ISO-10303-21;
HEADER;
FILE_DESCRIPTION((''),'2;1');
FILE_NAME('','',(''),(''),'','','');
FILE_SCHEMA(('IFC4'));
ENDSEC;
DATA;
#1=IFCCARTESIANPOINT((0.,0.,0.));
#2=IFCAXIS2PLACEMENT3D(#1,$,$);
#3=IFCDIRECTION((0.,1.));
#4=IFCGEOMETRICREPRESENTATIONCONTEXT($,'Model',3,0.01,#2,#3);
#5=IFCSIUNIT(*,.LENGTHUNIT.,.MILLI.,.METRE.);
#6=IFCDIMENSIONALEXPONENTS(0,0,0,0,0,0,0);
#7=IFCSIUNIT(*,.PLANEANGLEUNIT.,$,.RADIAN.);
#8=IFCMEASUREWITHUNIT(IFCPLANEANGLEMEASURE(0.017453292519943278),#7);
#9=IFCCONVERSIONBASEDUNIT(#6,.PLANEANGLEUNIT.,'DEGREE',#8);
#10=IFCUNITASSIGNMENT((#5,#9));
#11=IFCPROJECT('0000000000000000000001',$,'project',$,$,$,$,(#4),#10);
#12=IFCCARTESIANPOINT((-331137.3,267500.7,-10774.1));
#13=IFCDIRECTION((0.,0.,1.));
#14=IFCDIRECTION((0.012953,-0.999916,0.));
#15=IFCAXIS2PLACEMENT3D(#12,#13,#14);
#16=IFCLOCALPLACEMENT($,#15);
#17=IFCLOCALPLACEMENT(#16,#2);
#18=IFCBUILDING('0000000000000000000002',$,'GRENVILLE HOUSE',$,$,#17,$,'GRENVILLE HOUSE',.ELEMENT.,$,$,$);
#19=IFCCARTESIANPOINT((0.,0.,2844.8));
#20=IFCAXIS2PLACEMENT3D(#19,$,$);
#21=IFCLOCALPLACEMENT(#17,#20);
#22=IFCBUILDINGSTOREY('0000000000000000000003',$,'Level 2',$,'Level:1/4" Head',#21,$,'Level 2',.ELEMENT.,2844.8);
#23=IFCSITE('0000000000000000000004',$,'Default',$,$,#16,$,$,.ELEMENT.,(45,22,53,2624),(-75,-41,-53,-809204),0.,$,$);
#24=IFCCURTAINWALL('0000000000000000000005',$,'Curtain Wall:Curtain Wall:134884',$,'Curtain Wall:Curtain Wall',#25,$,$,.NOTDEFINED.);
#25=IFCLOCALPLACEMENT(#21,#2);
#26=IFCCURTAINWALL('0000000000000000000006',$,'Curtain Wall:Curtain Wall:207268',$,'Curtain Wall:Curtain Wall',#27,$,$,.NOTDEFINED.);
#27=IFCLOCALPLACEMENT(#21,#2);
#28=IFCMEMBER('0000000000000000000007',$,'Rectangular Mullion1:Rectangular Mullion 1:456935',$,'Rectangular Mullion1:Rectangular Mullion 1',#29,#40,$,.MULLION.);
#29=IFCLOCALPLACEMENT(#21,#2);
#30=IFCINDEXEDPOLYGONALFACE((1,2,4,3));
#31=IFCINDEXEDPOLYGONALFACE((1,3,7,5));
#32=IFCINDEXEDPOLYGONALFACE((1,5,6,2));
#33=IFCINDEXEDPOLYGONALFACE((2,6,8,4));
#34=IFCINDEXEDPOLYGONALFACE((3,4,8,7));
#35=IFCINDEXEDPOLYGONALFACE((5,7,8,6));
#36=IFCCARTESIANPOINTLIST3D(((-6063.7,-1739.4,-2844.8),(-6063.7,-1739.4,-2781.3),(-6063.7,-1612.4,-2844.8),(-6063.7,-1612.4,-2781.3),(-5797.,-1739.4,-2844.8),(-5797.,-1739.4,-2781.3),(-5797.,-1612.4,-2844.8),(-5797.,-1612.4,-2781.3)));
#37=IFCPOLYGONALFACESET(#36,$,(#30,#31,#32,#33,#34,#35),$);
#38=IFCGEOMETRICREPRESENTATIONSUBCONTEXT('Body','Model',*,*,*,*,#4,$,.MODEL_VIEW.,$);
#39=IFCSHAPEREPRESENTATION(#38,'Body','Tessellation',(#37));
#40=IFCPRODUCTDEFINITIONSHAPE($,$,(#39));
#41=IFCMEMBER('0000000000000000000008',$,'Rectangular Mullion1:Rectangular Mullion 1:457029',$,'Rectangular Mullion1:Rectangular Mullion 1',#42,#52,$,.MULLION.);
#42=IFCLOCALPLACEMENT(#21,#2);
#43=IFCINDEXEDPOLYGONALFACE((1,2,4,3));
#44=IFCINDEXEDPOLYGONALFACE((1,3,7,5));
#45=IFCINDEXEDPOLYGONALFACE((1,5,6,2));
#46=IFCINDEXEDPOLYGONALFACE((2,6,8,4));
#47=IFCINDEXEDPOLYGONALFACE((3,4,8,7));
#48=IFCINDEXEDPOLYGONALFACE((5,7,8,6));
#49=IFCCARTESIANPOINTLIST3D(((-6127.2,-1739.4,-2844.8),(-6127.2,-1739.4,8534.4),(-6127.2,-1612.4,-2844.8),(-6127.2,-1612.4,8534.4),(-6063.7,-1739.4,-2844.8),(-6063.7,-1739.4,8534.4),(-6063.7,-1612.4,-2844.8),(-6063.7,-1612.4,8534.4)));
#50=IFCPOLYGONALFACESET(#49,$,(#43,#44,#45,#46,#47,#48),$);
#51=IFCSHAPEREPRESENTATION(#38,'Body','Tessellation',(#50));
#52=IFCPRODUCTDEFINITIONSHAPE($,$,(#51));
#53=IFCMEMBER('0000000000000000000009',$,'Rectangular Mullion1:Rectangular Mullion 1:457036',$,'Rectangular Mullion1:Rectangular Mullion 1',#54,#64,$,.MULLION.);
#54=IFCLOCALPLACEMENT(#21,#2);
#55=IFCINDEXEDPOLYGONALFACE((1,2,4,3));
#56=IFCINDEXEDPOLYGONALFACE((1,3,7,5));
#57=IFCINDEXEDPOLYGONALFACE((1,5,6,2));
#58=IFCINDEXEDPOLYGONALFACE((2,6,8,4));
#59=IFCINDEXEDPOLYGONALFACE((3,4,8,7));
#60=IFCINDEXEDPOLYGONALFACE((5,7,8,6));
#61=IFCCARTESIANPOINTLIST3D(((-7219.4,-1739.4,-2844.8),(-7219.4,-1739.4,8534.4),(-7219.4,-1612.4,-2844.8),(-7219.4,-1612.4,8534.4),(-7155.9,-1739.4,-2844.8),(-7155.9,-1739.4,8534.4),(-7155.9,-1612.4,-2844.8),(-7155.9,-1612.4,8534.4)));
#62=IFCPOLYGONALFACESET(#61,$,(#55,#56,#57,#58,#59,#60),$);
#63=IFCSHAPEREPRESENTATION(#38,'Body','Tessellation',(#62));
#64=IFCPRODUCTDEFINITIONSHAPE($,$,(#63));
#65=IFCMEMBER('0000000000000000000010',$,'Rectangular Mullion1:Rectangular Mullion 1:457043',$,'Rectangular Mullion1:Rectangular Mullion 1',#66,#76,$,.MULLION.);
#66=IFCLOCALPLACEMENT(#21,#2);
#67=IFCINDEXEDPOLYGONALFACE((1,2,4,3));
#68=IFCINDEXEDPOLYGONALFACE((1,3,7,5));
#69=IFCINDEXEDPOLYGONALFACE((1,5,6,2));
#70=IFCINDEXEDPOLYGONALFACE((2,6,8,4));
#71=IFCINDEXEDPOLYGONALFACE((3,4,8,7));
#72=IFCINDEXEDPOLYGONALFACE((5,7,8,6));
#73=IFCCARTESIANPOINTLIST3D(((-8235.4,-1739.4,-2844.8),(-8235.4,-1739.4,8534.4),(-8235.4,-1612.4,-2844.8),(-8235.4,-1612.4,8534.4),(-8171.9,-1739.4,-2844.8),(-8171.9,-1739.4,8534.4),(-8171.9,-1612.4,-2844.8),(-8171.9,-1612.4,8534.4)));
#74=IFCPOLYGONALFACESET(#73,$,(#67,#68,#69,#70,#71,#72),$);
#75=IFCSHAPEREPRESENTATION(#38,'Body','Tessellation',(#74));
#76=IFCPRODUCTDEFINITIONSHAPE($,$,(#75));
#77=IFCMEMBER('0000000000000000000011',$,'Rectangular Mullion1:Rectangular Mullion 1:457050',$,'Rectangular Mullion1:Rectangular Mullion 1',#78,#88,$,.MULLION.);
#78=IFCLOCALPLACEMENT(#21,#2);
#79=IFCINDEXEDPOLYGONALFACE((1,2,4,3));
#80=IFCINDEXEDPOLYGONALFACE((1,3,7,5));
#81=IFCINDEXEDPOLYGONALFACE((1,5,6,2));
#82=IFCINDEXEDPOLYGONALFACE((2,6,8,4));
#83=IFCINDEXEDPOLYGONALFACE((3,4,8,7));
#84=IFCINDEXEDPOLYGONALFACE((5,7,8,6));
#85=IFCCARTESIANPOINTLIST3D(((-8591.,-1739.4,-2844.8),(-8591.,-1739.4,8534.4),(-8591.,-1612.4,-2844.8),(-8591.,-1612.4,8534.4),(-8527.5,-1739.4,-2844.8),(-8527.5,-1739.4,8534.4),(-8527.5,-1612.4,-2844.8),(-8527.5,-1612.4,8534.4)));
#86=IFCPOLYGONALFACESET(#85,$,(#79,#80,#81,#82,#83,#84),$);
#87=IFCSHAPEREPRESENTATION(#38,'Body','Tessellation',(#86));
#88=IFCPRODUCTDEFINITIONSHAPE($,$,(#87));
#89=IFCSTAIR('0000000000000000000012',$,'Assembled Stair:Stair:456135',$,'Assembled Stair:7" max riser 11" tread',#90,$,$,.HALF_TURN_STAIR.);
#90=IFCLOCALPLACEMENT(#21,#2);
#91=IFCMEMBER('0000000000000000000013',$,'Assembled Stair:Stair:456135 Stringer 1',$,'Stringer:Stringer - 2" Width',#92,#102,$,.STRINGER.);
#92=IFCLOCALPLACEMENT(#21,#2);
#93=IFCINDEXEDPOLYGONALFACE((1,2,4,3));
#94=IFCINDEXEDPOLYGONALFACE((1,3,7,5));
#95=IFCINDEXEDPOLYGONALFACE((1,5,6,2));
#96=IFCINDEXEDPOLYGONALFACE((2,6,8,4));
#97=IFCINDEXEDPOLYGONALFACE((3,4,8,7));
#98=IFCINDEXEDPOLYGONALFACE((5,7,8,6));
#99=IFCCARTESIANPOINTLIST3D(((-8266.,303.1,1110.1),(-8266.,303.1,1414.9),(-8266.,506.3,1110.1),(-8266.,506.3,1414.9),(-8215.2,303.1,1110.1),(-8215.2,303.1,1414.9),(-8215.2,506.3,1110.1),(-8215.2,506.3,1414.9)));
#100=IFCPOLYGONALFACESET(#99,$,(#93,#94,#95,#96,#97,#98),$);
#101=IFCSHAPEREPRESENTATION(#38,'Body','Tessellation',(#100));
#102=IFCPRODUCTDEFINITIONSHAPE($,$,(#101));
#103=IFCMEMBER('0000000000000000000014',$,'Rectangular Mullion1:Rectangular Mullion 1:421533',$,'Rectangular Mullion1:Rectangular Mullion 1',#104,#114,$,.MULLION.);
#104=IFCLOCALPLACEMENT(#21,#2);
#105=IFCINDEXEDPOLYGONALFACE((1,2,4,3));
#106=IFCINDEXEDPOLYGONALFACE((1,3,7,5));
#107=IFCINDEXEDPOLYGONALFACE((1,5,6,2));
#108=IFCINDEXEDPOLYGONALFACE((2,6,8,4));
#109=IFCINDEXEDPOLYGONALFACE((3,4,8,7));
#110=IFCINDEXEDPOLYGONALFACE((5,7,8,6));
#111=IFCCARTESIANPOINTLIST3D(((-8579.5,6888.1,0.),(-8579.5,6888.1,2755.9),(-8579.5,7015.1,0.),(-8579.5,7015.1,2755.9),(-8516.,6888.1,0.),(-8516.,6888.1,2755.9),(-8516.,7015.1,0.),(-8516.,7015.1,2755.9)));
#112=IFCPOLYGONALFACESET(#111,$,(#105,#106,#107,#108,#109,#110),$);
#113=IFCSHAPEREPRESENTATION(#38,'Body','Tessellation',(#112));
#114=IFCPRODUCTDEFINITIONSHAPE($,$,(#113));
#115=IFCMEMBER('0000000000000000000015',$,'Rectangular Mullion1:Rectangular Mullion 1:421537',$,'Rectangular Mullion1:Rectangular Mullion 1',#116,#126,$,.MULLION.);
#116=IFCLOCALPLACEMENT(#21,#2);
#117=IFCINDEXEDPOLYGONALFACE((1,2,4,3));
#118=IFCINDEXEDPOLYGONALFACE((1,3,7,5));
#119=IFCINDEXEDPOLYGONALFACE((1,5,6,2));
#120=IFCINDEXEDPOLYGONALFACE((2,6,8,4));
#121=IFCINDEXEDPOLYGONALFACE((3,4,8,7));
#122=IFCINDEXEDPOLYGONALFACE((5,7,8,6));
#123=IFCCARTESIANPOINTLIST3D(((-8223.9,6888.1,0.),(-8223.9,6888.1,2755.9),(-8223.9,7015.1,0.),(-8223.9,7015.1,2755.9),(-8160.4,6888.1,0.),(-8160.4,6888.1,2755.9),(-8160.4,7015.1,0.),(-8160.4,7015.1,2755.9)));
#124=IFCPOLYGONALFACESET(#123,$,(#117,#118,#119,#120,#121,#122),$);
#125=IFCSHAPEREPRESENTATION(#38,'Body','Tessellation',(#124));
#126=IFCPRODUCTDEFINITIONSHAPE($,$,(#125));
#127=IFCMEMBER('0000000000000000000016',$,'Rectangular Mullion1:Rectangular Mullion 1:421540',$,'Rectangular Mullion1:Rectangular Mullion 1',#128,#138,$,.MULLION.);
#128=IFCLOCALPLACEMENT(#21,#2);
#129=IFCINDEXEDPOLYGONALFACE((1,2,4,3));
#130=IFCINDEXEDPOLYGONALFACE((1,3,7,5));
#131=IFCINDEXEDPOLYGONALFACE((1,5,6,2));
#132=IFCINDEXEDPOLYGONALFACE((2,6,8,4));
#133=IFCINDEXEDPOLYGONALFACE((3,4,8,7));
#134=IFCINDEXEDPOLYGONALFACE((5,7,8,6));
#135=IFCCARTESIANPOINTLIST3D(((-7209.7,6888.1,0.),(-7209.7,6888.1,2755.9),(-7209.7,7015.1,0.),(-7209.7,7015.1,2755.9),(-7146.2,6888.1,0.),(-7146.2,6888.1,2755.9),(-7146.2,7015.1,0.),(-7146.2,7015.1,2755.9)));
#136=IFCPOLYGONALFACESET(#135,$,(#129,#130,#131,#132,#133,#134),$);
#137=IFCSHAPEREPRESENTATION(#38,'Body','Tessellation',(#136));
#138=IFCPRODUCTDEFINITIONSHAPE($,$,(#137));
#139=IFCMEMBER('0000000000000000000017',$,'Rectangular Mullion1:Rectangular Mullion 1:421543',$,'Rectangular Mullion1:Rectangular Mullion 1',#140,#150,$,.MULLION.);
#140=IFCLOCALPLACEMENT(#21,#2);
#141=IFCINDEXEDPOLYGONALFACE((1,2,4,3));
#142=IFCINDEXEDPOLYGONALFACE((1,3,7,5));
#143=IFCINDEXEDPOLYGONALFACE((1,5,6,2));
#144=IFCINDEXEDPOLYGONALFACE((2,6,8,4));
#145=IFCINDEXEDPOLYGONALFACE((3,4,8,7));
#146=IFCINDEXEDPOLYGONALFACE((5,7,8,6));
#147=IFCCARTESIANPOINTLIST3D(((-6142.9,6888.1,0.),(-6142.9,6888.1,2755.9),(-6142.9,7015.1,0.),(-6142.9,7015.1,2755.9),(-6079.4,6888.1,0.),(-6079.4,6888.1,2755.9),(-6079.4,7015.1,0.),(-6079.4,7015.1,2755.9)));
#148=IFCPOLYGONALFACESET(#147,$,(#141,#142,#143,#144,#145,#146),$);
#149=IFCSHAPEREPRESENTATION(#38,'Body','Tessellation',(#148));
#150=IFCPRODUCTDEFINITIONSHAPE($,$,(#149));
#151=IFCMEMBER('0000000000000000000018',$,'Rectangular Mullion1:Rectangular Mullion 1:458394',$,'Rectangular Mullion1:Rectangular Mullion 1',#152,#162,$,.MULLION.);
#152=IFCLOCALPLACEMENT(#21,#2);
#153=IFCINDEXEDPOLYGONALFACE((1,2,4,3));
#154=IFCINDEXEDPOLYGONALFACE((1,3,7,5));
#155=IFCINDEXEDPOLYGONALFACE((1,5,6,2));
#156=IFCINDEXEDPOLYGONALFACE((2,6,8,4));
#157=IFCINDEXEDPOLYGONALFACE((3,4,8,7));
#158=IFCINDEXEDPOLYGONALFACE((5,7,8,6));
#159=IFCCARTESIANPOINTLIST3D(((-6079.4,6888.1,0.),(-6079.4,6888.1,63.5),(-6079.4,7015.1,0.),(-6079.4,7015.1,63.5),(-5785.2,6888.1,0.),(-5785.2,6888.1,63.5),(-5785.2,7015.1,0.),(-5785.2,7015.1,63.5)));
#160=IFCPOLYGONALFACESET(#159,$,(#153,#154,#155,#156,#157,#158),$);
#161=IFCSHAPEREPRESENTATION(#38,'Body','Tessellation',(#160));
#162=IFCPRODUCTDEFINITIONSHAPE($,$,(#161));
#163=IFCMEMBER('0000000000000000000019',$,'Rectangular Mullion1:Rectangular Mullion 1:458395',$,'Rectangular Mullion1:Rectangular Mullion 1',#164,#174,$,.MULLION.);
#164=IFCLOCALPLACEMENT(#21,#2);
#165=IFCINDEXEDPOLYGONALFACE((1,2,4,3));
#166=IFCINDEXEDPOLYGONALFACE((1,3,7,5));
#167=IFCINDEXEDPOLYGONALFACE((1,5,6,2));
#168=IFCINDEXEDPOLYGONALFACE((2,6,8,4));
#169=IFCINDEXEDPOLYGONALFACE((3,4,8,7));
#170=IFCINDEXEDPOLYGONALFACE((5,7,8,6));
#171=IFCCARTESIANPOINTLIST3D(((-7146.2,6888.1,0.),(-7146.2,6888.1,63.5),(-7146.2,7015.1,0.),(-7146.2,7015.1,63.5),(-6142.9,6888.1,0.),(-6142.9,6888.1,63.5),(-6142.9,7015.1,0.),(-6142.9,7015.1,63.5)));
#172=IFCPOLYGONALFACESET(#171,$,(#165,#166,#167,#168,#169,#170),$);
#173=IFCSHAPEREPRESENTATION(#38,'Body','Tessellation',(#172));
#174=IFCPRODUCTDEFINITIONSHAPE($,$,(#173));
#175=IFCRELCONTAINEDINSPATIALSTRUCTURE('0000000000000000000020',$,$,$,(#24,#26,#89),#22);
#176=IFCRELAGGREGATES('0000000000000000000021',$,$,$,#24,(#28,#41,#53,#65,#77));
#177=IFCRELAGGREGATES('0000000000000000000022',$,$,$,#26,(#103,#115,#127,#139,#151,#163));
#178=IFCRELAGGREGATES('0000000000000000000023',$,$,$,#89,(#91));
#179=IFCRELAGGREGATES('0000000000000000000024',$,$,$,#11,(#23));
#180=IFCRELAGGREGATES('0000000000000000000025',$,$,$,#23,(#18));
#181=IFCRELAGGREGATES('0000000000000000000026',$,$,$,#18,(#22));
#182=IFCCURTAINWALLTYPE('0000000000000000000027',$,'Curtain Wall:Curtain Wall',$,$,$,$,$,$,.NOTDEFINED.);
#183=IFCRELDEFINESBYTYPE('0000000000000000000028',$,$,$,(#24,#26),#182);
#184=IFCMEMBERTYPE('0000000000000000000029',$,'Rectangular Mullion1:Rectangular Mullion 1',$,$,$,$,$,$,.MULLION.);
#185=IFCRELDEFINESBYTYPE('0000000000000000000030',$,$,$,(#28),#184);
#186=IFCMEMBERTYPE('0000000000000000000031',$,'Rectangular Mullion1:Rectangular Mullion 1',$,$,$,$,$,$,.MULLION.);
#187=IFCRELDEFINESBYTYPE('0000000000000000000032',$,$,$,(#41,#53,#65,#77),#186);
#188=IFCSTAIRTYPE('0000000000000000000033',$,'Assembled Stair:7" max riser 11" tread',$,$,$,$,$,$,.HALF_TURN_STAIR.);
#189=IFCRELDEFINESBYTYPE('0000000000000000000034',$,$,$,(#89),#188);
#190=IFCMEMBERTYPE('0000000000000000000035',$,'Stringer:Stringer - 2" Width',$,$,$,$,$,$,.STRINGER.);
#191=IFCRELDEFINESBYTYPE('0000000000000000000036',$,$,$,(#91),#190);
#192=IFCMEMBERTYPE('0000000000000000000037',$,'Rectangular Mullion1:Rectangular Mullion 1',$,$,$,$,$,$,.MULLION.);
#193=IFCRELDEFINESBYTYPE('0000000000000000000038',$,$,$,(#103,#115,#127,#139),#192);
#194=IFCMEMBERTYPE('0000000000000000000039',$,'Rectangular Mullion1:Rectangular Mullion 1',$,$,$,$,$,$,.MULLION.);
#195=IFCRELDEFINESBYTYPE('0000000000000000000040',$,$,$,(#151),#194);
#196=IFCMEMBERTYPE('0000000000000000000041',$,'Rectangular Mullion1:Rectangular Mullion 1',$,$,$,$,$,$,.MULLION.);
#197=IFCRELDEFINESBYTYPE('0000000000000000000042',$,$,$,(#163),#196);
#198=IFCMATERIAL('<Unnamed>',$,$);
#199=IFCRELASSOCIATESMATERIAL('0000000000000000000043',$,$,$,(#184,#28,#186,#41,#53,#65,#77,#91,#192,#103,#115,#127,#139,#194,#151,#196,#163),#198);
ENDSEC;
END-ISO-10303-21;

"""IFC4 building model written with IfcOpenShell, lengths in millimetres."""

from ifc_helpers import new_model, entity, si_unit, converted_unit, direction, frame, origin, place, context, subcontext, project, spatial, indexed_curve, outline, extrude, source, transform, mapped, material, type_object, type_shapes, element, aggregate, save


model = new_model("IFC4")

# Units and contexts
model_context = context("Model", 3, precision=0.01, world=origin(), true_north=direction((0.0, 1.0)))
body_context = subcontext(model_context, "Body", "Model", "MODEL_VIEW")
ifc_project = project(units=[si_unit("LENGTHUNIT", "METRE", prefix="MILLI"), converted_unit("PLANEANGLEUNIT", "DEGREE", entity("IfcPlaneAngleMeasure", 0.017453292519943278), si_unit("PLANEANGLEUNIT", "RADIAN"), dimensions=[0, 0, 0, 0, 0, 0, 0])], contexts=[model_context])

# Site, building, storey
site_placement = place(None, frame((-331137.3, 267500.7, -10774.1), z_axis=(0.0, 0.0, 1.0), x_axis=(0.012953, -0.999916, 0.0)))
site = spatial("IfcSite", under=ifc_project, at=site_placement, Name="Default", CompositionType="ELEMENT", RefLatitude=(45, 22, 53, 2624), RefLongitude=(-75, -41, -53, -809204), RefElevation=0.0)
building_placement = place(site_placement, origin())
building = spatial("IfcBuilding", under=site, at=building_placement, Name="GRENVILLE HOUSE", LongName="GRENVILLE HOUSE", CompositionType="ELEMENT")
storey_placement = place(building_placement, frame((0.0, 0.0, 2844.8)))
storey = spatial("IfcBuildingStorey", under=building, at=storey_placement, Name="Level 2", ObjectType="Level:1/4\" Head", LongName="Level 2", CompositionType="ELEMENT", Elevation=2844.8)

# Curtain wall
curtain_wall_type = type_object("IfcCurtainWallType", Name="Curtain Wall:Curtain Wall", PredefinedType="NOTDEFINED")
curtain_wall_1_placement = place(storey_placement, frame((0.0, 0.0, -2844.8)))
curtain_wall_1 = element("IfcCurtainWall", 1, at=curtain_wall_1_placement, inside=storey, type_object=curtain_wall_type, Name="Curtain Wall:Curtain Wall:134884", ObjectType="Curtain Wall:Curtain Wall", PredefinedType="NOTDEFINED")
ifc_material_1 = material(Name="<Unnamed>")

# Curtain wall
curtain_wall_2_placement = place(storey_placement, frame((0.0, 0.0, -2844.8)))
curtain_wall_2 = element("IfcCurtainWall", 2, at=curtain_wall_2_placement, inside=storey, type_object=curtain_wall_type, Name="Curtain Wall:Curtain Wall:207268", ObjectType="Curtain Wall:Curtain Wall", PredefinedType="NOTDEFINED")

# Members
member_type_1 = type_object("IfcMemberType", Name="Rectangular Mullion1:Rectangular Mullion 1", PredefinedType="MULLION", material=ifc_material_1)
shared_shape_1 = source(origin(), body_context, "Body", "SweptSolid", [
    extrude(outline(indexed_curve([(-31.8, -63.5), (31.8, -63.5), (31.8, 63.5), (-31.8, 63.5), (-31.8, -63.5)], self_intersect=False)), frame((-31.8, 0.0, -266.7), z_axis=(0.0, 0.0, 1.0), x_axis=(-1.0, 0.0, 0.0)), (0.0, 0.0, 1.0), 266.7),
])
type_shapes(member_type_1, [shared_shape_1])
member_1_placement = place(curtain_wall_1_placement, frame((-6063.7, -1675.9, 0.0), z_axis=(-1.0, 0.0, 0.0), x_axis=(0.0, 0.0, -1.0)))
member_1 = element("IfcMember", 3, at=member_1_placement, type_object=member_type_1, material=ifc_material_1, Name="Rectangular Mullion1:Rectangular Mullion 1:456935", ObjectType="Rectangular Mullion1:Rectangular Mullion 1", PredefinedType="MULLION", context=body_context, shape_type="MappedRepresentation", body=[
    mapped(shared_shape_1, transform((0.0, 0.0, 0.0), scale=1.0)),
])
member_type_2 = type_object("IfcMemberType", Name="Rectangular Mullion1:Rectangular Mullion 1", PredefinedType="MULLION", material=ifc_material_1)
shared_shape_2 = source(origin(), body_context, "Body", "SweptSolid", [
    extrude(outline(indexed_curve([(-31.8, -63.5), (31.8, -63.5), (31.8, 63.5), (-31.8, 63.5), (-31.8, -63.5)], self_intersect=False)), frame((0.0, 0.0, -11379.2), z_axis=(0.0, 0.0, 1.0), x_axis=(-1.0, 0.0, 0.0)), (0.0, 0.0, 1.0), 11379.2),
])
type_shapes(member_type_2, [shared_shape_2])
member_2_placement = place(curtain_wall_1_placement, frame((-6095.4, -1675.9, 0.0), z_axis=(0.0, 0.0, -1.0), x_axis=(1.0, 0.0, 0.0)))
member_2 = element("IfcMember", 4, at=member_2_placement, type_object=member_type_2, material=ifc_material_1, Name="Rectangular Mullion1:Rectangular Mullion 1:457029", ObjectType="Rectangular Mullion1:Rectangular Mullion 1", PredefinedType="MULLION", context=body_context, shape_type="MappedRepresentation", body=[
    mapped(shared_shape_2, transform((0.0, 0.0, 0.0), scale=1.0)),
])
member_3_placement = place(curtain_wall_1_placement, frame((-7187.6, -1675.9, 0.0), z_axis=(0.0, 0.0, -1.0), x_axis=(1.0, 0.0, 0.0)))
member_3 = element("IfcMember", 5, at=member_3_placement, type_object=member_type_2, material=ifc_material_1, Name="Rectangular Mullion1:Rectangular Mullion 1:457036", ObjectType="Rectangular Mullion1:Rectangular Mullion 1", PredefinedType="MULLION", context=body_context, shape_type="MappedRepresentation", body=[
    mapped(shared_shape_2, transform((0.0, 0.0, 0.0), scale=1.0)),
])
member_4_placement = place(curtain_wall_1_placement, frame((-8203.6, -1675.9, 0.0), z_axis=(0.0, 0.0, -1.0), x_axis=(1.0, 0.0, 0.0)))
member_4 = element("IfcMember", 6, at=member_4_placement, type_object=member_type_2, material=ifc_material_1, Name="Rectangular Mullion1:Rectangular Mullion 1:457043", ObjectType="Rectangular Mullion1:Rectangular Mullion 1", PredefinedType="MULLION", context=body_context, shape_type="MappedRepresentation", body=[
    mapped(shared_shape_2, transform((0.0, 0.0, 0.0), scale=1.0)),
])
member_5_placement = place(curtain_wall_1_placement, frame((-8559.2, -1675.9, 0.0), z_axis=(0.0, 0.0, -1.0), x_axis=(1.0, 0.0, 0.0)))
member_5 = element("IfcMember", 7, at=member_5_placement, type_object=member_type_2, material=ifc_material_1, Name="Rectangular Mullion1:Rectangular Mullion 1:457050", ObjectType="Rectangular Mullion1:Rectangular Mullion 1", PredefinedType="MULLION", context=body_context, shape_type="MappedRepresentation", body=[
    mapped(shared_shape_2, transform((0.0, 0.0, 0.0), scale=1.0)),
])

# Stair, member
stair_type = type_object("IfcStairType", Name="Assembled Stair:7\" max riser 11\" tread", PredefinedType="HALF_TURN_STAIR")
stair_placement = place(storey_placement, origin())
stair = element("IfcStair", 8, at=stair_placement, inside=storey, type_object=stair_type, Name="Assembled Stair:Stair:456135", ObjectType="Assembled Stair:7\" max riser 11\" tread", PredefinedType="HALF_TURN_STAIR")
member_type_3 = type_object("IfcMemberType", Name="Stringer:Stringer - 2\" Width", PredefinedType="STRINGER")
member_6_placement = place(stair_placement, frame((-8266.0, 303.1, 1110.1)))
member_6 = element("IfcMember", 9, at=member_6_placement, type_object=member_type_3, material=ifc_material_1, Name="Assembled Stair:Stair:456135 Stringer 1", ObjectType="Stringer:Stringer - 2\" Width", PredefinedType="STRINGER", context=body_context, shape_type="SweptSolid", body=[
    extrude(outline(indexed_curve([(-101.6, -25.4), (101.6, -25.4), (101.6, 25.4), (-101.6, 25.4), (-101.6, -25.4)], self_intersect=False)), frame((25.4, 101.6, 0.0), z_axis=(0.0, 0.0, 1.0), x_axis=(0.0, 1.0, 0.0)), (0.0, 0.0, 1.0), 304.8),
])

# Members
member_type_4 = type_object("IfcMemberType", Name="Rectangular Mullion1:Rectangular Mullion 1", PredefinedType="MULLION", material=ifc_material_1)
shared_shape_3 = source(origin(), body_context, "Body", "SweptSolid", [
    extrude(outline(indexed_curve([(-31.8, -63.5), (31.8, -63.5), (31.8, 63.5), (-31.8, 63.5), (-31.8, -63.5)], self_intersect=False)), frame((0.0, 0.0, -2755.9), z_axis=(0.0, 0.0, 1.0), x_axis=(-1.0, 0.0, 0.0)), (0.0, 0.0, 1.0), 2755.9),
])
type_shapes(member_type_4, [shared_shape_3])
member_7_placement = place(curtain_wall_2_placement, frame((-8547.7, 6951.6, 2844.8), z_axis=(0.0, 0.0, -1.0), x_axis=(-1.0, 0.0, 0.0)))
member_7 = element("IfcMember", 10, at=member_7_placement, type_object=member_type_4, material=ifc_material_1, Name="Rectangular Mullion1:Rectangular Mullion 1:421533", ObjectType="Rectangular Mullion1:Rectangular Mullion 1", PredefinedType="MULLION", context=body_context, shape_type="MappedRepresentation", body=[
    mapped(shared_shape_3, transform((0.0, 0.0, 0.0), scale=1.0)),
])
member_8_placement = place(curtain_wall_2_placement, frame((-8192.1, 6951.6, 2844.8), z_axis=(0.0, 0.0, -1.0), x_axis=(-1.0, 0.0, 0.0)))
member_8 = element("IfcMember", 11, at=member_8_placement, type_object=member_type_4, material=ifc_material_1, Name="Rectangular Mullion1:Rectangular Mullion 1:421537", ObjectType="Rectangular Mullion1:Rectangular Mullion 1", PredefinedType="MULLION", context=body_context, shape_type="MappedRepresentation", body=[
    mapped(shared_shape_3, transform((0.0, 0.0, 0.0), scale=1.0)),
])
member_9_placement = place(curtain_wall_2_placement, frame((-7177.9, 6951.6, 2844.8), z_axis=(0.0, 0.0, -1.0), x_axis=(-1.0, 0.0, 0.0)))
member_9 = element("IfcMember", 12, at=member_9_placement, type_object=member_type_4, material=ifc_material_1, Name="Rectangular Mullion1:Rectangular Mullion 1:421540", ObjectType="Rectangular Mullion1:Rectangular Mullion 1", PredefinedType="MULLION", context=body_context, shape_type="MappedRepresentation", body=[
    mapped(shared_shape_3, transform((0.0, 0.0, 0.0), scale=1.0)),
])
member_10_placement = place(curtain_wall_2_placement, frame((-6111.1, 6951.6, 2844.8), z_axis=(0.0, 0.0, -1.0), x_axis=(-1.0, 0.0, 0.0)))
member_10 = element("IfcMember", 13, at=member_10_placement, type_object=member_type_4, material=ifc_material_1, Name="Rectangular Mullion1:Rectangular Mullion 1:421543", ObjectType="Rectangular Mullion1:Rectangular Mullion 1", PredefinedType="MULLION", context=body_context, shape_type="MappedRepresentation", body=[
    mapped(shared_shape_3, transform((0.0, 0.0, 0.0), scale=1.0)),
])
member_type_5 = type_object("IfcMemberType", Name="Rectangular Mullion1:Rectangular Mullion 1", PredefinedType="MULLION", material=ifc_material_1)
shared_shape_4 = source(origin(), body_context, "Body", "SweptSolid", [
    extrude(outline(indexed_curve([(-31.8, -63.5), (31.8, -63.5), (31.8, 63.5), (-31.8, 63.5), (-31.8, -63.5)], self_intersect=False)), frame((-31.8, 0.0, -294.2), z_axis=(0.0, 0.0, 1.0), x_axis=(-1.0, 0.0, 0.0)), (0.0, 0.0, 1.0), 294.2),
])
type_shapes(member_type_5, [shared_shape_4])
member_11_placement = place(curtain_wall_2_placement, frame((-5785.2, 6951.6, 2844.8), z_axis=(1.0, 0.0, 0.0), x_axis=(0.0, 0.0, -1.0)))
member_11 = element("IfcMember", 14, at=member_11_placement, type_object=member_type_5, material=ifc_material_1, Name="Rectangular Mullion1:Rectangular Mullion 1:458394", ObjectType="Rectangular Mullion1:Rectangular Mullion 1", PredefinedType="MULLION", context=body_context, shape_type="MappedRepresentation", body=[
    mapped(shared_shape_4, transform((0.0, 0.0, 0.0), scale=1.0)),
])
member_type_6 = type_object("IfcMemberType", Name="Rectangular Mullion1:Rectangular Mullion 1", PredefinedType="MULLION", material=ifc_material_1)
shared_shape_5 = source(origin(), body_context, "Body", "SweptSolid", [
    extrude(outline(indexed_curve([(-31.8, -63.5), (31.8, -63.5), (31.8, 63.5), (-31.8, 63.5), (-31.8, -63.5)], self_intersect=False)), frame((-31.8, 0.0, -1003.3), z_axis=(0.0, 0.0, 1.0), x_axis=(-1.0, 0.0, 0.0)), (0.0, 0.0, 1.0), 1003.3),
])
type_shapes(member_type_6, [shared_shape_5])
member_12_placement = place(curtain_wall_2_placement, frame((-6142.9, 6951.6, 2844.8), z_axis=(1.0, 0.0, 0.0), x_axis=(0.0, 0.0, -1.0)))
member_12 = element("IfcMember", 15, at=member_12_placement, type_object=member_type_6, material=ifc_material_1, Name="Rectangular Mullion1:Rectangular Mullion 1:458395", ObjectType="Rectangular Mullion1:Rectangular Mullion 1", PredefinedType="MULLION", context=body_context, shape_type="MappedRepresentation", body=[
    mapped(shared_shape_5, transform((0.0, 0.0, 0.0), scale=1.0)),
])

aggregate(curtain_wall_1, [member_1, member_2, member_3, member_4, member_5])
aggregate(curtain_wall_2, [member_7, member_8, member_9, member_10, member_11, member_12])

aggregate(stair, [member_6])

save(model, "model.ifc")
